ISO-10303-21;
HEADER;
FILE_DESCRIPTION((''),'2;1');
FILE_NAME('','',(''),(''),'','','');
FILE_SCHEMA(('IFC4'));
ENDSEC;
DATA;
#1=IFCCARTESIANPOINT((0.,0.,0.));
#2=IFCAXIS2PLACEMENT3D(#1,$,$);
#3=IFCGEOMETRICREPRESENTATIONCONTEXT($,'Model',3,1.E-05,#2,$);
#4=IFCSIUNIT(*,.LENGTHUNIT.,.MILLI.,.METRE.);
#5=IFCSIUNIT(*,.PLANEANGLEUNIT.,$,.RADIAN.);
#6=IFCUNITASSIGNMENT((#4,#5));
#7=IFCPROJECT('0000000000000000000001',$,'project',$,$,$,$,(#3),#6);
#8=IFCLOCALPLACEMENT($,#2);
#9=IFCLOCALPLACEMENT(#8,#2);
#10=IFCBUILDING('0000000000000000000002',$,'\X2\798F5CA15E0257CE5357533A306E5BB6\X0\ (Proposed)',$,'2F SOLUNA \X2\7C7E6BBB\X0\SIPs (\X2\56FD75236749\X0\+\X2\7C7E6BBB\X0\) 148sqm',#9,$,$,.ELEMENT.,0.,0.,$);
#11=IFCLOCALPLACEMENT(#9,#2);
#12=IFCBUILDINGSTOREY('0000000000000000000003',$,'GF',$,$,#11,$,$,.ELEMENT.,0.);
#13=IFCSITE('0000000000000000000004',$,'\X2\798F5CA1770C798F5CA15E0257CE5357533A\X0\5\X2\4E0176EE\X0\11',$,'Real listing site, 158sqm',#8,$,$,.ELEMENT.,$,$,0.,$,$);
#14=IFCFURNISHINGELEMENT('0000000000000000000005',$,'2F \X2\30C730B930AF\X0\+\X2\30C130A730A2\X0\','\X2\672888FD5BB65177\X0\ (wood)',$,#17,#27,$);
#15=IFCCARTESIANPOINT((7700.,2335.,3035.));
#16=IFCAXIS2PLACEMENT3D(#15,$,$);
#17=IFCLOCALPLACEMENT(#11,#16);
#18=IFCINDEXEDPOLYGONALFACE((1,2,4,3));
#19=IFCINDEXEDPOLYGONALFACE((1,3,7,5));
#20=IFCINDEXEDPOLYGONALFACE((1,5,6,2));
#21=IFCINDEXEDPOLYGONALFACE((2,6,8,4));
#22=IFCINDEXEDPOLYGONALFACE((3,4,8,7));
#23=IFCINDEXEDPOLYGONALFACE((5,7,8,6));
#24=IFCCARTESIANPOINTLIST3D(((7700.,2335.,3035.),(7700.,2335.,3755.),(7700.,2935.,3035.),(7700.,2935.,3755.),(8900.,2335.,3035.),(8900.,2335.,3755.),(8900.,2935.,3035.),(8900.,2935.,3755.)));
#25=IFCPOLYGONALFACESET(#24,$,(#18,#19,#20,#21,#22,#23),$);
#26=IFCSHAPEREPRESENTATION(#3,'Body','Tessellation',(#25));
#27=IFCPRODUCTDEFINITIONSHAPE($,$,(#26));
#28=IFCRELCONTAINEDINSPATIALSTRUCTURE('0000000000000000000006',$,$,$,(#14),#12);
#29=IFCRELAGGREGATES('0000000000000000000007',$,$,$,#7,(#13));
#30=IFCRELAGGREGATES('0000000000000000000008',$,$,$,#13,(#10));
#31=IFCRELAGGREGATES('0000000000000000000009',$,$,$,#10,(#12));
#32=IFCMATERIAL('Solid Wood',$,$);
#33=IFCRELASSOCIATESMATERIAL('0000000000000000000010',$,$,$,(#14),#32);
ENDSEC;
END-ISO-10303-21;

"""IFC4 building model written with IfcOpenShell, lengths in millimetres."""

from ifc_helpers import new_model, si_unit, frame, frame_2d, origin, place, context, project, spatial, rectangle, extrude, material, element, save


model = new_model("IFC4")

# Units and contexts
model_context = context("Model", 3, precision=1e-05, world=origin())
ifc_project = project(units=[si_unit("LENGTHUNIT", "METRE", prefix="MILLI"), si_unit("PLANEANGLEUNIT", "RADIAN")], contexts=[model_context])

# Site, building, storey
site_placement = place(None, origin())
site = spatial("IfcSite", under=ifc_project, at=site_placement, Name="福岡県福岡市城南区5丁目11", ObjectType="Real listing site, 158sqm", CompositionType="ELEMENT", RefElevation=0.0)
building_placement = place(site_placement, origin())
building = spatial("IfcBuilding", under=site, at=building_placement, Name="福岡市城南区の家 (Proposed)", ObjectType="2F SOLUNA 籾殻SIPs (国産杉+籾殻) 148sqm", CompositionType="ELEMENT", ElevationOfRefHeight=0.0, ElevationOfTerrain=0.0)
storey_placement = place(building_placement, origin())
storey = spatial("IfcBuildingStorey", under=building, at=storey_placement, Name="GF", CompositionType="ELEMENT", Elevation=0.0)

# Shared definitions
ifc_material_1 = material(Name="Solid Wood")

# Furnishing element
furnishing_1_placement = place(storey_placement, frame((7700.0, 2335.0, 3035.0)))
element("IfcFurnishingElement", 1, at=furnishing_1_placement, inside=storey, material=ifc_material_1, Name="2F デスク+チェア", Description="木製家具 (wood)", context=model_context, shape_type="SweptSolid", body=[
    extrude(rectangle(XDim=1200.0, YDim=600.0, at=frame_2d((600.0, 300.0))), frame((7700.0, 2335.0, 3035.0)), (0.0, 0.0, 1.0), 720.0),
])

save(model, "model.ifc")
